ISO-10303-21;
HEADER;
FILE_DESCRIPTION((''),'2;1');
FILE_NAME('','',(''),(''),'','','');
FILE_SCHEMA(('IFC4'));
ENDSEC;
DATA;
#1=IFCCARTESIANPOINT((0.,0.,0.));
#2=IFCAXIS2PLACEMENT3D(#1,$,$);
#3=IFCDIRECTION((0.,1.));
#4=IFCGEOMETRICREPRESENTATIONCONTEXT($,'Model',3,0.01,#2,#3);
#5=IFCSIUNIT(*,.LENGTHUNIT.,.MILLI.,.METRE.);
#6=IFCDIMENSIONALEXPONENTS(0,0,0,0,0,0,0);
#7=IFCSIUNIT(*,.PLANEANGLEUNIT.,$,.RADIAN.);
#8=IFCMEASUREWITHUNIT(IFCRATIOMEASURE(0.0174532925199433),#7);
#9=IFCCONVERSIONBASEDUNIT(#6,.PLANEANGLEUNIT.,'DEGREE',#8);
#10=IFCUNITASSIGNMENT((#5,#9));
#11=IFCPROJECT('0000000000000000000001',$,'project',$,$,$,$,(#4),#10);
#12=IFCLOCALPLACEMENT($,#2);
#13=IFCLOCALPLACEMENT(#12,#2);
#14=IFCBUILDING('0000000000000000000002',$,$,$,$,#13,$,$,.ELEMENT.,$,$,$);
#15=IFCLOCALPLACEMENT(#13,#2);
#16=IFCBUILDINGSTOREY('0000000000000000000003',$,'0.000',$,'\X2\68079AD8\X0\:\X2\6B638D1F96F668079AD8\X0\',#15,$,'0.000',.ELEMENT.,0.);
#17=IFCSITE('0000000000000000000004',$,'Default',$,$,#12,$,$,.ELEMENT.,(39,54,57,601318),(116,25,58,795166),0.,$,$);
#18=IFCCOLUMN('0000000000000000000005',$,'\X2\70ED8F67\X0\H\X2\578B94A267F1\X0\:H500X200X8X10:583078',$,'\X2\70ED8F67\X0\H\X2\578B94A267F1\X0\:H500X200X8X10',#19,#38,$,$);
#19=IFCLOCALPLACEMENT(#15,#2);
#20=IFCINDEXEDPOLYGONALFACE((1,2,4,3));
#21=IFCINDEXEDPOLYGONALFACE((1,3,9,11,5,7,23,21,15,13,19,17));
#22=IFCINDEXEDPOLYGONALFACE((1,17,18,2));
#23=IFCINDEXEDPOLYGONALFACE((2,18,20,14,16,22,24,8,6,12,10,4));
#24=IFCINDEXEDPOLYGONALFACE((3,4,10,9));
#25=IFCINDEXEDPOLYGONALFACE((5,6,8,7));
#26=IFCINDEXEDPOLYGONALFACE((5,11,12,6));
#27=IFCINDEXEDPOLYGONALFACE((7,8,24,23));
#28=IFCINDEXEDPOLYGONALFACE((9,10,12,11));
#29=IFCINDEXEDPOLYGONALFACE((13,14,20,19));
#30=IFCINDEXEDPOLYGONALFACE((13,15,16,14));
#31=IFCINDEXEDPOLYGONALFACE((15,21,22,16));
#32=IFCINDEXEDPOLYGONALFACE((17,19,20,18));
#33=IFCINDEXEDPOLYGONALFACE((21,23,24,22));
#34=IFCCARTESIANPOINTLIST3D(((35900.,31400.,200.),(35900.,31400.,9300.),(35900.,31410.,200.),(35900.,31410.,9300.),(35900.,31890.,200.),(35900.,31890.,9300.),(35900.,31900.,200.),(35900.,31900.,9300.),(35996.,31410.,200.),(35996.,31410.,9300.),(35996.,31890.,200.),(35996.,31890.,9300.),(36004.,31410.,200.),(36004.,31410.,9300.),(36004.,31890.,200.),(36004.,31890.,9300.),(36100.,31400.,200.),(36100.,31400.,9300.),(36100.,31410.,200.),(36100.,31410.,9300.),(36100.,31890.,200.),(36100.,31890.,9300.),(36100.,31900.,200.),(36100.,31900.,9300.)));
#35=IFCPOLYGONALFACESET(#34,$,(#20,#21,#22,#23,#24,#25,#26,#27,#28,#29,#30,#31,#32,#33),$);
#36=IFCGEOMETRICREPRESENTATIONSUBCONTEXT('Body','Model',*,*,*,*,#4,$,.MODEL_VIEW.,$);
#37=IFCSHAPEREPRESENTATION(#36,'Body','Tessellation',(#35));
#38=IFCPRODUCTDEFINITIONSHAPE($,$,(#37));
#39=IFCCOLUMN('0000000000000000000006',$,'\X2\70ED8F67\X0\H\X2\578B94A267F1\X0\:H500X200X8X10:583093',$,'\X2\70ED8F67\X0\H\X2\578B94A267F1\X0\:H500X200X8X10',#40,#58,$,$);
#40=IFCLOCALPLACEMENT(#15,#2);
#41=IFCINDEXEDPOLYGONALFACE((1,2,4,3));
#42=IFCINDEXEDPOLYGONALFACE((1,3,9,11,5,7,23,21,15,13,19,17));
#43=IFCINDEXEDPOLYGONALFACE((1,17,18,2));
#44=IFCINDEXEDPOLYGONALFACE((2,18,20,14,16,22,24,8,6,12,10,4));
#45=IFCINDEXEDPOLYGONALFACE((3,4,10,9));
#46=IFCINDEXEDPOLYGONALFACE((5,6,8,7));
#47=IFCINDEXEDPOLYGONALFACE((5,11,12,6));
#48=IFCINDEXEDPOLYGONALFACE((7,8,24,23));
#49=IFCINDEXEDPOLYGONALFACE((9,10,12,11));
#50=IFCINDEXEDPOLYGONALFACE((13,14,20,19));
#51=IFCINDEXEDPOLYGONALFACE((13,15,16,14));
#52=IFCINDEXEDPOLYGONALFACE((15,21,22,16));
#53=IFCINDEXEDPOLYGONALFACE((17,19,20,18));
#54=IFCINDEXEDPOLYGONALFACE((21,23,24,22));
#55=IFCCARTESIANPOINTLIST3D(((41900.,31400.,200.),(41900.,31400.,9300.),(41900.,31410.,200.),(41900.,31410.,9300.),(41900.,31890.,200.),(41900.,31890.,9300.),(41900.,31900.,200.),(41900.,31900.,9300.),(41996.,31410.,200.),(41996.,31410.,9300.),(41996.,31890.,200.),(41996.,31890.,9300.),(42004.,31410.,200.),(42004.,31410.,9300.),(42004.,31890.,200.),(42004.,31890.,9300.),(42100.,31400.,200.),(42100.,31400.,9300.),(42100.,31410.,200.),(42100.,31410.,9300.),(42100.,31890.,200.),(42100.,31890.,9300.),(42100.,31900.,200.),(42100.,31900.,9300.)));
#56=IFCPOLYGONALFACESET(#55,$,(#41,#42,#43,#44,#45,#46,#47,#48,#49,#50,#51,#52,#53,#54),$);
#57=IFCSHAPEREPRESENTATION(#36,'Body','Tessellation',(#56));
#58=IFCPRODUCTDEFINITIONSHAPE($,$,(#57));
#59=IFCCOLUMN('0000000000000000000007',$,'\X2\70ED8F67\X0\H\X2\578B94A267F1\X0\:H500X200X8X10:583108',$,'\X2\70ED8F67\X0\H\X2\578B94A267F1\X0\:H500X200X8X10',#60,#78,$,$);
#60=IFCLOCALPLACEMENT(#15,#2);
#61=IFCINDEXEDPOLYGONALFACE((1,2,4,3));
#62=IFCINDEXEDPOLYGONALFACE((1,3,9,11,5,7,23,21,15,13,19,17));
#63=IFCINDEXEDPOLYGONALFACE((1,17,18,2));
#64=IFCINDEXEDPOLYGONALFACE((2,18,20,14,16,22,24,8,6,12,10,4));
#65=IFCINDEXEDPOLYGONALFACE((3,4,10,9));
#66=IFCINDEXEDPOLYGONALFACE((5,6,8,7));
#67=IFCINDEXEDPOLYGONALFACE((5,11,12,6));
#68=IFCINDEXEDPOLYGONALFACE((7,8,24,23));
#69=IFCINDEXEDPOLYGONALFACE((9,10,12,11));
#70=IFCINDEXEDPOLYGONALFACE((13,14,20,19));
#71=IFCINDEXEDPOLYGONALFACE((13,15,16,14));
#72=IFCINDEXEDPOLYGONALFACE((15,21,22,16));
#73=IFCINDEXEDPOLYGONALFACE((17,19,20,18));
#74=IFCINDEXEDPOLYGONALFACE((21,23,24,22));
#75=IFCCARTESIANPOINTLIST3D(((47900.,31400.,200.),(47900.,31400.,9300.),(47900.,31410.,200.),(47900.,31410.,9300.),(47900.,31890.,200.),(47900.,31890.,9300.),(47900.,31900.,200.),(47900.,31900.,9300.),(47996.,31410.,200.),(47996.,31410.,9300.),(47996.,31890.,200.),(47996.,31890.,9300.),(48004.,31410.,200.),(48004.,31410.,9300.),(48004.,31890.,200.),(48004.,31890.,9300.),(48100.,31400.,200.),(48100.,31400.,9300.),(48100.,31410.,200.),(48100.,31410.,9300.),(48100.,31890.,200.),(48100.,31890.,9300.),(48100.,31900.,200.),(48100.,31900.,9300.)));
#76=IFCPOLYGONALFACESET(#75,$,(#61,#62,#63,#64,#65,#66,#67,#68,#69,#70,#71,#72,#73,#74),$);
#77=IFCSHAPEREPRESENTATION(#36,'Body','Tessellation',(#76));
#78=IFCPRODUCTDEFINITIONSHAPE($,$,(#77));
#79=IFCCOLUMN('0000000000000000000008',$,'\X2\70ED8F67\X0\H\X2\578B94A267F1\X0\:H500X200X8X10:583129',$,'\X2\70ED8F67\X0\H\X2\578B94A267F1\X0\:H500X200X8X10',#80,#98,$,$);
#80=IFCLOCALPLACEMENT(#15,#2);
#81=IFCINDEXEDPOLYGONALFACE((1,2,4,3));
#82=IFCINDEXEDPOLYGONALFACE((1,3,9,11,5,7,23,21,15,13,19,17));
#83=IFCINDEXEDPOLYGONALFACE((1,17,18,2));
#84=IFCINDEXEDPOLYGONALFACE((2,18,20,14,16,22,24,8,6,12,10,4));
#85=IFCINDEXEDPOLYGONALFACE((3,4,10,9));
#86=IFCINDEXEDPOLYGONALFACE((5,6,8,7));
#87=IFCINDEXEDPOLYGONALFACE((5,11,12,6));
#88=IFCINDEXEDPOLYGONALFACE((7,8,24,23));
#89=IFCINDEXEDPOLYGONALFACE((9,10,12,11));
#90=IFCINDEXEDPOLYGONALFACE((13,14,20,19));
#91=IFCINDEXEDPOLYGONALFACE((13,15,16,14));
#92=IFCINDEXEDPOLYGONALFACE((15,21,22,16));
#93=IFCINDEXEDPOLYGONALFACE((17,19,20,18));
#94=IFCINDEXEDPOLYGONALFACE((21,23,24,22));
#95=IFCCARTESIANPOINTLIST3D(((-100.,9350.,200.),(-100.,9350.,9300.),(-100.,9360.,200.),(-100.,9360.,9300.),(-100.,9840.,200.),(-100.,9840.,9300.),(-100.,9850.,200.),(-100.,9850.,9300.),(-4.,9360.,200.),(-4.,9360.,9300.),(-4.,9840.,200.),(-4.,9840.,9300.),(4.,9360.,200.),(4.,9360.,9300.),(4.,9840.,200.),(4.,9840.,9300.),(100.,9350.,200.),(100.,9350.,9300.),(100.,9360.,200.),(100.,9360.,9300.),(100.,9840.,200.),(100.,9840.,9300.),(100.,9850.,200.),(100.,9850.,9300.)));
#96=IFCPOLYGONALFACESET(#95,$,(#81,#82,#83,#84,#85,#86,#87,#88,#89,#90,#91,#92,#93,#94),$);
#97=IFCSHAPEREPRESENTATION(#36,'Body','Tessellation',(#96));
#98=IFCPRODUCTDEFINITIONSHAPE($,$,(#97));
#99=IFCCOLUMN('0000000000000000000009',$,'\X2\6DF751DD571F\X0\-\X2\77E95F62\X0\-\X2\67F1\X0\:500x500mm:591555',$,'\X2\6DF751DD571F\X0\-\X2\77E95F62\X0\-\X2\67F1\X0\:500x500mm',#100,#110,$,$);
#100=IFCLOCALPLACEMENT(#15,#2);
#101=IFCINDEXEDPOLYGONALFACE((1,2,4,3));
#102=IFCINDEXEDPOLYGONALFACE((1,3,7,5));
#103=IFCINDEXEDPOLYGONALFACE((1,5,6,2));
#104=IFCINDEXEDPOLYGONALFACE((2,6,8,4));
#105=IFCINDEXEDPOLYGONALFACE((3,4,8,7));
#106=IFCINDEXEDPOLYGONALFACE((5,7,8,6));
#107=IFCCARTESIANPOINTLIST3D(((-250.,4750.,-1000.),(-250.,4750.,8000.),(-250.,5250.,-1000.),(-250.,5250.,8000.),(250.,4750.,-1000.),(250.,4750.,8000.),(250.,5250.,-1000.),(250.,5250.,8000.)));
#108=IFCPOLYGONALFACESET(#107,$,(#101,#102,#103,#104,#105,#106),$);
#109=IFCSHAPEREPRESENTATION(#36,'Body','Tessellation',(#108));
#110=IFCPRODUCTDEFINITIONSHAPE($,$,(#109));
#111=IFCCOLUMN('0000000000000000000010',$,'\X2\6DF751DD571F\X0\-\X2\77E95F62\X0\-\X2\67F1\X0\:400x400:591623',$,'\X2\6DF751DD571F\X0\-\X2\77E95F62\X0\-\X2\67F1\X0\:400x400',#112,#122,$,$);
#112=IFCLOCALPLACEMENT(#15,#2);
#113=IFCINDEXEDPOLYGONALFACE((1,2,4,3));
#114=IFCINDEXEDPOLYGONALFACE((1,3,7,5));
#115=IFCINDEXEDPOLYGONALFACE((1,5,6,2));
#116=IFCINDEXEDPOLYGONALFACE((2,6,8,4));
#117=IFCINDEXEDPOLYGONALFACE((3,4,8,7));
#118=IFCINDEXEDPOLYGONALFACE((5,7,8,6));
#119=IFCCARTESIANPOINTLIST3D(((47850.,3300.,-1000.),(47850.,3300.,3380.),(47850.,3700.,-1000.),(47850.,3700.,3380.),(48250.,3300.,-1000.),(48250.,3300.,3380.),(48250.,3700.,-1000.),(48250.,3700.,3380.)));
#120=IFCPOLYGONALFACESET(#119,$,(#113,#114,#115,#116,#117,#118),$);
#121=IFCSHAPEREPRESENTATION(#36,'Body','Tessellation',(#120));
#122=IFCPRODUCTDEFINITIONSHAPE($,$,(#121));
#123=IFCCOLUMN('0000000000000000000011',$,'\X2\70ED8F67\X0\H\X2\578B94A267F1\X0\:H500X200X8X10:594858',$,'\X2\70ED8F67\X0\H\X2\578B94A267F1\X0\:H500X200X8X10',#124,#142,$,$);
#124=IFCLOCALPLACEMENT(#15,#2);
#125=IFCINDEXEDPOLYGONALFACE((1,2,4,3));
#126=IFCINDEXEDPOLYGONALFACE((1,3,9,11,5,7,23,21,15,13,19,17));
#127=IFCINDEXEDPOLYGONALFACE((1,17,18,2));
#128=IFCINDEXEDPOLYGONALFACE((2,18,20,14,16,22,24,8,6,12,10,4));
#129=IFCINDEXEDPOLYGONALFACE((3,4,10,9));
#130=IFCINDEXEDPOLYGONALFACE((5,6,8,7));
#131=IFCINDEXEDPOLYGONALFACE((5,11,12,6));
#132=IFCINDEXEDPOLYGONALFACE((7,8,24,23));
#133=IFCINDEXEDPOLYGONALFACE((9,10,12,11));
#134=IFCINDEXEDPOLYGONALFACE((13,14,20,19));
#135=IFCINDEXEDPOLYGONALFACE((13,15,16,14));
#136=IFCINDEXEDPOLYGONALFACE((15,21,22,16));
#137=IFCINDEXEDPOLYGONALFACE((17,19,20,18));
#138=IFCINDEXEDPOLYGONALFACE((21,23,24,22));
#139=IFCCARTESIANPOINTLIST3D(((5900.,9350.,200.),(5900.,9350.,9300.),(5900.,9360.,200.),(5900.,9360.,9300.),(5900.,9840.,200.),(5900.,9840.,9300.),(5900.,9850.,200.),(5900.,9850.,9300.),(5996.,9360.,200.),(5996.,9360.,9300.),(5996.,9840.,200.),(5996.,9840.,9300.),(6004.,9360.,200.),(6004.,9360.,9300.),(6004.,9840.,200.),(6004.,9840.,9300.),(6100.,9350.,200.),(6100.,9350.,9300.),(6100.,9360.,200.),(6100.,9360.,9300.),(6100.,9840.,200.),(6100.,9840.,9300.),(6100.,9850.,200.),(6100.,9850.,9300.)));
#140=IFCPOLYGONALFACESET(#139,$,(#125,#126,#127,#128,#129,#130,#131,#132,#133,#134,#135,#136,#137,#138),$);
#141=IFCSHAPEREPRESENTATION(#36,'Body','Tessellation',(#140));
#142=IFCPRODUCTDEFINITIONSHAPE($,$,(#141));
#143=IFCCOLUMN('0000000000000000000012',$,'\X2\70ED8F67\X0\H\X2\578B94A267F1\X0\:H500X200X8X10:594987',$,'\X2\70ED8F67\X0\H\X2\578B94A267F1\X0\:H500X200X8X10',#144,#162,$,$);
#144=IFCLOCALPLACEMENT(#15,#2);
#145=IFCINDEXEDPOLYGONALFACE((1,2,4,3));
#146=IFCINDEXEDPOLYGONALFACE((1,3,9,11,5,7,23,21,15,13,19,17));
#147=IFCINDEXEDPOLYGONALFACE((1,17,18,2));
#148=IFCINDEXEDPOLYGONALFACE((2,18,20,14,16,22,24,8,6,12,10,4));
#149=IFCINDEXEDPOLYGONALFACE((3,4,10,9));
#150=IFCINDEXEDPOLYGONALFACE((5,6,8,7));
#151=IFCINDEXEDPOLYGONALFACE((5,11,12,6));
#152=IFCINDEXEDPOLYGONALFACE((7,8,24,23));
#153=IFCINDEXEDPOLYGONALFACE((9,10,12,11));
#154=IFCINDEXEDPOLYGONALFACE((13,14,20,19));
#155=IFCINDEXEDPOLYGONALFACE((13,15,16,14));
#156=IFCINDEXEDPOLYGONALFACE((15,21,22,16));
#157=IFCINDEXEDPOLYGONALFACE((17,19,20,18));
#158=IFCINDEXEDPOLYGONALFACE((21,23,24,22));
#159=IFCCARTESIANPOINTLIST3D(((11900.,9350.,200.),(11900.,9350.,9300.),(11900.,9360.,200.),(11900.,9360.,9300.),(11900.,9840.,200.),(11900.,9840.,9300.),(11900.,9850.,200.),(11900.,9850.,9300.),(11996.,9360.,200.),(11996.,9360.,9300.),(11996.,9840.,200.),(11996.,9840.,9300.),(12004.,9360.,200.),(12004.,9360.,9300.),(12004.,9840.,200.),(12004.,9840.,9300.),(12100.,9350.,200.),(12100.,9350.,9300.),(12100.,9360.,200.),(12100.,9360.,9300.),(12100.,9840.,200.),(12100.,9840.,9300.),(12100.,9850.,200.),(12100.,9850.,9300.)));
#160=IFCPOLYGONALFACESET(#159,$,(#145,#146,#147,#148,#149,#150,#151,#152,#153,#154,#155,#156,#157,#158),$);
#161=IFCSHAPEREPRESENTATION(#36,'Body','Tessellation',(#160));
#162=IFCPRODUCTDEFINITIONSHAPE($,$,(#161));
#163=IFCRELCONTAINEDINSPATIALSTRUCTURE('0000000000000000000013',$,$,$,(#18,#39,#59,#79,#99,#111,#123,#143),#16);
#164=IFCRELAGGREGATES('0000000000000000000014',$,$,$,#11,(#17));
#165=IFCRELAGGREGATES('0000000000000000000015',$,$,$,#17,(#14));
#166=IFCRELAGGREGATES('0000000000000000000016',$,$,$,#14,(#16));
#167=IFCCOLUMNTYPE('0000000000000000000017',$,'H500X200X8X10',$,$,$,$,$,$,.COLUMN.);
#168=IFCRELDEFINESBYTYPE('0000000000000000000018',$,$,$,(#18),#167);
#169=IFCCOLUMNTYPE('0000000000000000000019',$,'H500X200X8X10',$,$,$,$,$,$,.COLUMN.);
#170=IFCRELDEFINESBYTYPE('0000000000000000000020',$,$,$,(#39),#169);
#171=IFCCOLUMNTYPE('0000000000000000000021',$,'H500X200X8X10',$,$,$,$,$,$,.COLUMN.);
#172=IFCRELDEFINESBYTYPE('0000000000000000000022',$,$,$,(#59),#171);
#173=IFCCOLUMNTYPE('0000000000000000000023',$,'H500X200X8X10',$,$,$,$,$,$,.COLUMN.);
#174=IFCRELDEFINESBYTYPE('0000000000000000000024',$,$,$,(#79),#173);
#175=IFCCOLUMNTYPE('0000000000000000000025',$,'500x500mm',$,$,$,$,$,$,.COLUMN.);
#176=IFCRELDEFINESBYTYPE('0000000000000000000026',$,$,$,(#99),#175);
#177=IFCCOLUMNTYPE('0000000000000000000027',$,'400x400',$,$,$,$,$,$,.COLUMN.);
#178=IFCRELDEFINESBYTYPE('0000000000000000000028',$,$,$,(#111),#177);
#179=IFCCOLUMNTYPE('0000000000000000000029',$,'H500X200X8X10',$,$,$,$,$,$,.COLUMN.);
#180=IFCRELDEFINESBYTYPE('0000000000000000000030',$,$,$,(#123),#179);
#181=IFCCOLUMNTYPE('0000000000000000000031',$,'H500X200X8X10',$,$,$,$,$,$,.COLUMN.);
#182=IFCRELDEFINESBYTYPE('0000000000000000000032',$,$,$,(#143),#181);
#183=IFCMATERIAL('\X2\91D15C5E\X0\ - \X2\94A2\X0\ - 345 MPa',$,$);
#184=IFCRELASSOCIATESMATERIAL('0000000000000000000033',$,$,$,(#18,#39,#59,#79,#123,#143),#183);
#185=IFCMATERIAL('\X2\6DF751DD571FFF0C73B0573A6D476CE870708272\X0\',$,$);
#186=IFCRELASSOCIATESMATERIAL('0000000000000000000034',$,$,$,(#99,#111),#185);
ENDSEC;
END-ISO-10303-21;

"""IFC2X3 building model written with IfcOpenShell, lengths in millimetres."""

from ifc_helpers import new_model, entity, si_unit, converted_unit, direction, frame, frame_2d, origin, origin_2d_with_axis, place, context, subcontext, project, spatial, polyline, rectangle, i_section, outline, extrude, source, transform, mapped, material, type_object, type_shapes, element, save


model = new_model("IFC2X3")

# Units and contexts
model_context = context("Model", 3, precision=0.01, world=origin(), true_north=direction((0.0, 1.0)))
body_context = subcontext(model_context, "Body", "Model", "MODEL_VIEW")
ifc_project = project(units=[si_unit("LENGTHUNIT", "METRE", prefix="MILLI"), converted_unit("PLANEANGLEUNIT", "DEGREE", entity("IfcRatioMeasure", 0.0174532925199433), si_unit("PLANEANGLEUNIT", "RADIAN"), dimensions=[0, 0, 0, 0, 0, 0, 0])], contexts=[model_context])

# Site, building, storey
site_placement = place(None, origin())
site = spatial("IfcSite", under=ifc_project, at=site_placement, Name="Default", CompositionType="ELEMENT", RefLatitude=(39, 54, 57, 601318), RefLongitude=(116, 25, 58, 795166), RefElevation=0.0)
building_placement = place(site_placement, origin())
building = spatial("IfcBuilding", under=site, at=building_placement, CompositionType="ELEMENT")
storey_placement = place(building_placement, origin())
storey = spatial("IfcBuildingStorey", under=building, at=storey_placement, Name="0.000", ObjectType="标高:正负零标高", LongName="0.000", CompositionType="ELEMENT", Elevation=0.0)

# Columns
ifc_material_1 = material(Name="混凝土，现场浇注灰色")
ifc_material_2 = material(Name="金属 - 钢 - 345 MPa")
column_type_1 = type_object("IfcColumnType", Name="H500X200X8X10", PredefinedType="COLUMN")
shared_shape_1 = source(origin(), body_context, "Body", "SweptSolid", [
    extrude(outline(polyline([(240.0, -100.0), (250.0, -100.0), (250.0, 100.0), (240.0, 100.0), (240.0, 4.0), (-240.0, 4.0), (-240.0, 100.0), (-250.0, 100.0), (-250.0, -100.0), (-240.0, -100.0), (-240.0, -4.0), (240.0, -4.0), (240.0, -100.0)])), frame((36000.0, 31650.0, 200.0), z_axis=(0.0, 0.0, 1.0), x_axis=(0.0, -1.0, 0.0)), (0.0, 0.0, 1.0), 9100.0),
])
type_shapes(column_type_1, [shared_shape_1])
column_1_placement = place(storey_placement, origin())
element("IfcColumn", 1, at=column_1_placement, inside=storey, type_object=column_type_1, material=ifc_material_2, Name="热轧H型钢柱:H500X200X8X10:583078", ObjectType="热轧H型钢柱:H500X200X8X10", context=body_context, shape_type="MappedRepresentation", body=[
    mapped(shared_shape_1, transform((0.0, 0.0, 0.0), scale=1.0)),
])
column_type_2 = type_object("IfcColumnType", Name="H500X200X8X10", PredefinedType="COLUMN")
shared_shape_2 = source(origin(), body_context, "Body", "SweptSolid", [
    extrude(outline(polyline([(240.0, -100.0), (250.0, -100.0), (250.0, 100.0), (240.0, 100.0), (240.0, 4.0), (-240.0, 4.0), (-240.0, 100.0), (-250.0, 100.0), (-250.0, -100.0), (-240.0, -100.0), (-240.0, -4.0), (240.0, -4.0), (240.0, -100.0)])), frame((42000.0, 31650.0, 200.0), z_axis=(0.0, 0.0, 1.0), x_axis=(0.0, -1.0, 0.0)), (0.0, 0.0, 1.0), 9100.0),
])
type_shapes(column_type_2, [shared_shape_2])
column_2_placement = place(storey_placement, origin())
element("IfcColumn", 2, at=column_2_placement, inside=storey, type_object=column_type_2, material=ifc_material_2, Name="热轧H型钢柱:H500X200X8X10:583093", ObjectType="热轧H型钢柱:H500X200X8X10", context=body_context, shape_type="MappedRepresentation", body=[
    mapped(shared_shape_2, transform((0.0, 0.0, 0.0), scale=1.0)),
])
column_type_3 = type_object("IfcColumnType", Name="H500X200X8X10", PredefinedType="COLUMN")
shared_shape_3 = source(origin(), body_context, "Body", "SweptSolid", [
    extrude(outline(polyline([(240.0, -100.0), (250.0, -100.0), (250.0, 100.0), (240.0, 100.0), (240.0, 4.0), (-240.0, 4.0), (-240.0, 100.0), (-250.0, 100.0), (-250.0, -100.0), (-240.0, -100.0), (-240.0, -4.0), (240.0, -4.0), (240.0, -100.0)])), frame((48000.0, 31650.0, 200.0), z_axis=(0.0, 0.0, 1.0), x_axis=(0.0, -1.0, 0.0)), (0.0, 0.0, 1.0), 9100.0),
])
type_shapes(column_type_3, [shared_shape_3])
column_3_placement = place(storey_placement, origin())
element("IfcColumn", 3, at=column_3_placement, inside=storey, type_object=column_type_3, material=ifc_material_2, Name="热轧H型钢柱:H500X200X8X10:583108", ObjectType="热轧H型钢柱:H500X200X8X10", context=body_context, shape_type="MappedRepresentation", body=[
    mapped(shared_shape_3, transform((0.0, 0.0, 0.0), scale=1.0)),
])
column_type_4 = type_object("IfcColumnType", Name="H500X200X8X10", PredefinedType="COLUMN")
shared_shape_4 = source(origin(), body_context, "Body", "SweptSolid", [
    extrude(i_section(OverallWidth=200.0, OverallDepth=500.0, WebThickness=8.0, FlangeThickness=10.0, at=frame_2d((0.0, 0.0), x_axis=(0.0, 1.0))), frame((0.0, 9600.0, 200.0), z_axis=(0.0, 0.0, 1.0), x_axis=(0.0, -1.0, 0.0)), (0.0, 0.0, 1.0), 9100.0),
])
type_shapes(column_type_4, [shared_shape_4])
column_4_placement = place(storey_placement, origin())
element("IfcColumn", 4, at=column_4_placement, inside=storey, type_object=column_type_4, material=ifc_material_2, Name="热轧H型钢柱:H500X200X8X10:583129", ObjectType="热轧H型钢柱:H500X200X8X10", context=body_context, shape_type="MappedRepresentation", body=[
    mapped(shared_shape_4, transform((0.0, 0.0, 0.0), scale=1.0)),
])
column_type_5 = type_object("IfcColumnType", Name="500x500mm", PredefinedType="COLUMN")
shared_shape_5 = source(origin(), body_context, "Body", "SweptSolid", [
    extrude(rectangle(XDim=500.0, YDim=500.0, at=frame_2d((0.0, 0.0), x_axis=(1.0, 0.0))), frame((0.0, 5000.0, -1000.0), z_axis=(0.0, 0.0, 1.0), x_axis=(0.0, -1.0, 0.0)), (0.0, 0.0, 1.0), 9000.0),
])
type_shapes(column_type_5, [shared_shape_5])
column_5_placement = place(storey_placement, origin())
element("IfcColumn", 5, at=column_5_placement, inside=storey, type_object=column_type_5, material=ifc_material_1, Name="混凝土-矩形-柱:500x500mm:591555", ObjectType="混凝土-矩形-柱:500x500mm", context=body_context, shape_type="MappedRepresentation", body=[
    mapped(shared_shape_5, transform((0.0, 0.0, 0.0), scale=1.0)),
])
column_type_6 = type_object("IfcColumnType", Name="400x400", PredefinedType="COLUMN")
shared_shape_6 = source(origin(), body_context, "Body", "SweptSolid", [
    extrude(rectangle(XDim=400.0, YDim=400.0, at=origin_2d_with_axis()), frame((48050.0, 3500.0, -1000.0), z_axis=(0.0, 0.0, 1.0), x_axis=(0.0, -1.0, 0.0)), (0.0, 0.0, 1.0), 4380.0),
])
type_shapes(column_type_6, [shared_shape_6])
column_6_placement = place(storey_placement, origin())
element("IfcColumn", 6, at=column_6_placement, inside=storey, type_object=column_type_6, material=ifc_material_1, Name="混凝土-矩形-柱:400x400:591623", ObjectType="混凝土-矩形-柱:400x400", context=body_context, shape_type="MappedRepresentation", body=[
    mapped(shared_shape_6, transform((0.0, 0.0, 0.0), scale=1.0)),
])
column_type_7 = type_object("IfcColumnType", Name="H500X200X8X10", PredefinedType="COLUMN")
shared_shape_7 = source(origin(), body_context, "Body", "SweptSolid", [
    extrude(i_section(OverallWidth=200.0, OverallDepth=500.0, WebThickness=8.0, FlangeThickness=10.0, at=frame_2d((0.0, 0.0), x_axis=(0.0, 1.0))), frame((6000.0, 9600.0, 200.0), z_axis=(0.0, 0.0, 1.0), x_axis=(0.0, -1.0, 0.0)), (0.0, 0.0, 1.0), 9100.0),
])
type_shapes(column_type_7, [shared_shape_7])
column_7_placement = place(storey_placement, origin())
element("IfcColumn", 7, at=column_7_placement, inside=storey, type_object=column_type_7, material=ifc_material_2, Name="热轧H型钢柱:H500X200X8X10:594858", ObjectType="热轧H型钢柱:H500X200X8X10", context=body_context, shape_type="MappedRepresentation", body=[
    mapped(shared_shape_7, transform((0.0, 0.0, 0.0), scale=1.0)),
])
column_type_8 = type_object("IfcColumnType", Name="H500X200X8X10", PredefinedType="COLUMN")
shared_shape_8 = source(origin(), body_context, "Body", "SweptSolid", [
    extrude(i_section(OverallWidth=200.0, OverallDepth=500.0, WebThickness=8.0, FlangeThickness=10.0, at=frame_2d((0.0, 0.0), x_axis=(0.0, 1.0))), frame((12000.0, 9600.0, 200.0), z_axis=(0.0, 0.0, 1.0), x_axis=(0.0, -1.0, 0.0)), (0.0, 0.0, 1.0), 9100.0),
])
type_shapes(column_type_8, [shared_shape_8])
column_8_placement = place(storey_placement, origin())
element("IfcColumn", 8, at=column_8_placement, inside=storey, type_object=column_type_8, material=ifc_material_2, Name="热轧H型钢柱:H500X200X8X10:594987", ObjectType="热轧H型钢柱:H500X200X8X10", context=body_context, shape_type="MappedRepresentation", body=[
    mapped(shared_shape_8, transform((0.0, 0.0, 0.0), scale=1.0)),
])

save(model, "model.ifc")
